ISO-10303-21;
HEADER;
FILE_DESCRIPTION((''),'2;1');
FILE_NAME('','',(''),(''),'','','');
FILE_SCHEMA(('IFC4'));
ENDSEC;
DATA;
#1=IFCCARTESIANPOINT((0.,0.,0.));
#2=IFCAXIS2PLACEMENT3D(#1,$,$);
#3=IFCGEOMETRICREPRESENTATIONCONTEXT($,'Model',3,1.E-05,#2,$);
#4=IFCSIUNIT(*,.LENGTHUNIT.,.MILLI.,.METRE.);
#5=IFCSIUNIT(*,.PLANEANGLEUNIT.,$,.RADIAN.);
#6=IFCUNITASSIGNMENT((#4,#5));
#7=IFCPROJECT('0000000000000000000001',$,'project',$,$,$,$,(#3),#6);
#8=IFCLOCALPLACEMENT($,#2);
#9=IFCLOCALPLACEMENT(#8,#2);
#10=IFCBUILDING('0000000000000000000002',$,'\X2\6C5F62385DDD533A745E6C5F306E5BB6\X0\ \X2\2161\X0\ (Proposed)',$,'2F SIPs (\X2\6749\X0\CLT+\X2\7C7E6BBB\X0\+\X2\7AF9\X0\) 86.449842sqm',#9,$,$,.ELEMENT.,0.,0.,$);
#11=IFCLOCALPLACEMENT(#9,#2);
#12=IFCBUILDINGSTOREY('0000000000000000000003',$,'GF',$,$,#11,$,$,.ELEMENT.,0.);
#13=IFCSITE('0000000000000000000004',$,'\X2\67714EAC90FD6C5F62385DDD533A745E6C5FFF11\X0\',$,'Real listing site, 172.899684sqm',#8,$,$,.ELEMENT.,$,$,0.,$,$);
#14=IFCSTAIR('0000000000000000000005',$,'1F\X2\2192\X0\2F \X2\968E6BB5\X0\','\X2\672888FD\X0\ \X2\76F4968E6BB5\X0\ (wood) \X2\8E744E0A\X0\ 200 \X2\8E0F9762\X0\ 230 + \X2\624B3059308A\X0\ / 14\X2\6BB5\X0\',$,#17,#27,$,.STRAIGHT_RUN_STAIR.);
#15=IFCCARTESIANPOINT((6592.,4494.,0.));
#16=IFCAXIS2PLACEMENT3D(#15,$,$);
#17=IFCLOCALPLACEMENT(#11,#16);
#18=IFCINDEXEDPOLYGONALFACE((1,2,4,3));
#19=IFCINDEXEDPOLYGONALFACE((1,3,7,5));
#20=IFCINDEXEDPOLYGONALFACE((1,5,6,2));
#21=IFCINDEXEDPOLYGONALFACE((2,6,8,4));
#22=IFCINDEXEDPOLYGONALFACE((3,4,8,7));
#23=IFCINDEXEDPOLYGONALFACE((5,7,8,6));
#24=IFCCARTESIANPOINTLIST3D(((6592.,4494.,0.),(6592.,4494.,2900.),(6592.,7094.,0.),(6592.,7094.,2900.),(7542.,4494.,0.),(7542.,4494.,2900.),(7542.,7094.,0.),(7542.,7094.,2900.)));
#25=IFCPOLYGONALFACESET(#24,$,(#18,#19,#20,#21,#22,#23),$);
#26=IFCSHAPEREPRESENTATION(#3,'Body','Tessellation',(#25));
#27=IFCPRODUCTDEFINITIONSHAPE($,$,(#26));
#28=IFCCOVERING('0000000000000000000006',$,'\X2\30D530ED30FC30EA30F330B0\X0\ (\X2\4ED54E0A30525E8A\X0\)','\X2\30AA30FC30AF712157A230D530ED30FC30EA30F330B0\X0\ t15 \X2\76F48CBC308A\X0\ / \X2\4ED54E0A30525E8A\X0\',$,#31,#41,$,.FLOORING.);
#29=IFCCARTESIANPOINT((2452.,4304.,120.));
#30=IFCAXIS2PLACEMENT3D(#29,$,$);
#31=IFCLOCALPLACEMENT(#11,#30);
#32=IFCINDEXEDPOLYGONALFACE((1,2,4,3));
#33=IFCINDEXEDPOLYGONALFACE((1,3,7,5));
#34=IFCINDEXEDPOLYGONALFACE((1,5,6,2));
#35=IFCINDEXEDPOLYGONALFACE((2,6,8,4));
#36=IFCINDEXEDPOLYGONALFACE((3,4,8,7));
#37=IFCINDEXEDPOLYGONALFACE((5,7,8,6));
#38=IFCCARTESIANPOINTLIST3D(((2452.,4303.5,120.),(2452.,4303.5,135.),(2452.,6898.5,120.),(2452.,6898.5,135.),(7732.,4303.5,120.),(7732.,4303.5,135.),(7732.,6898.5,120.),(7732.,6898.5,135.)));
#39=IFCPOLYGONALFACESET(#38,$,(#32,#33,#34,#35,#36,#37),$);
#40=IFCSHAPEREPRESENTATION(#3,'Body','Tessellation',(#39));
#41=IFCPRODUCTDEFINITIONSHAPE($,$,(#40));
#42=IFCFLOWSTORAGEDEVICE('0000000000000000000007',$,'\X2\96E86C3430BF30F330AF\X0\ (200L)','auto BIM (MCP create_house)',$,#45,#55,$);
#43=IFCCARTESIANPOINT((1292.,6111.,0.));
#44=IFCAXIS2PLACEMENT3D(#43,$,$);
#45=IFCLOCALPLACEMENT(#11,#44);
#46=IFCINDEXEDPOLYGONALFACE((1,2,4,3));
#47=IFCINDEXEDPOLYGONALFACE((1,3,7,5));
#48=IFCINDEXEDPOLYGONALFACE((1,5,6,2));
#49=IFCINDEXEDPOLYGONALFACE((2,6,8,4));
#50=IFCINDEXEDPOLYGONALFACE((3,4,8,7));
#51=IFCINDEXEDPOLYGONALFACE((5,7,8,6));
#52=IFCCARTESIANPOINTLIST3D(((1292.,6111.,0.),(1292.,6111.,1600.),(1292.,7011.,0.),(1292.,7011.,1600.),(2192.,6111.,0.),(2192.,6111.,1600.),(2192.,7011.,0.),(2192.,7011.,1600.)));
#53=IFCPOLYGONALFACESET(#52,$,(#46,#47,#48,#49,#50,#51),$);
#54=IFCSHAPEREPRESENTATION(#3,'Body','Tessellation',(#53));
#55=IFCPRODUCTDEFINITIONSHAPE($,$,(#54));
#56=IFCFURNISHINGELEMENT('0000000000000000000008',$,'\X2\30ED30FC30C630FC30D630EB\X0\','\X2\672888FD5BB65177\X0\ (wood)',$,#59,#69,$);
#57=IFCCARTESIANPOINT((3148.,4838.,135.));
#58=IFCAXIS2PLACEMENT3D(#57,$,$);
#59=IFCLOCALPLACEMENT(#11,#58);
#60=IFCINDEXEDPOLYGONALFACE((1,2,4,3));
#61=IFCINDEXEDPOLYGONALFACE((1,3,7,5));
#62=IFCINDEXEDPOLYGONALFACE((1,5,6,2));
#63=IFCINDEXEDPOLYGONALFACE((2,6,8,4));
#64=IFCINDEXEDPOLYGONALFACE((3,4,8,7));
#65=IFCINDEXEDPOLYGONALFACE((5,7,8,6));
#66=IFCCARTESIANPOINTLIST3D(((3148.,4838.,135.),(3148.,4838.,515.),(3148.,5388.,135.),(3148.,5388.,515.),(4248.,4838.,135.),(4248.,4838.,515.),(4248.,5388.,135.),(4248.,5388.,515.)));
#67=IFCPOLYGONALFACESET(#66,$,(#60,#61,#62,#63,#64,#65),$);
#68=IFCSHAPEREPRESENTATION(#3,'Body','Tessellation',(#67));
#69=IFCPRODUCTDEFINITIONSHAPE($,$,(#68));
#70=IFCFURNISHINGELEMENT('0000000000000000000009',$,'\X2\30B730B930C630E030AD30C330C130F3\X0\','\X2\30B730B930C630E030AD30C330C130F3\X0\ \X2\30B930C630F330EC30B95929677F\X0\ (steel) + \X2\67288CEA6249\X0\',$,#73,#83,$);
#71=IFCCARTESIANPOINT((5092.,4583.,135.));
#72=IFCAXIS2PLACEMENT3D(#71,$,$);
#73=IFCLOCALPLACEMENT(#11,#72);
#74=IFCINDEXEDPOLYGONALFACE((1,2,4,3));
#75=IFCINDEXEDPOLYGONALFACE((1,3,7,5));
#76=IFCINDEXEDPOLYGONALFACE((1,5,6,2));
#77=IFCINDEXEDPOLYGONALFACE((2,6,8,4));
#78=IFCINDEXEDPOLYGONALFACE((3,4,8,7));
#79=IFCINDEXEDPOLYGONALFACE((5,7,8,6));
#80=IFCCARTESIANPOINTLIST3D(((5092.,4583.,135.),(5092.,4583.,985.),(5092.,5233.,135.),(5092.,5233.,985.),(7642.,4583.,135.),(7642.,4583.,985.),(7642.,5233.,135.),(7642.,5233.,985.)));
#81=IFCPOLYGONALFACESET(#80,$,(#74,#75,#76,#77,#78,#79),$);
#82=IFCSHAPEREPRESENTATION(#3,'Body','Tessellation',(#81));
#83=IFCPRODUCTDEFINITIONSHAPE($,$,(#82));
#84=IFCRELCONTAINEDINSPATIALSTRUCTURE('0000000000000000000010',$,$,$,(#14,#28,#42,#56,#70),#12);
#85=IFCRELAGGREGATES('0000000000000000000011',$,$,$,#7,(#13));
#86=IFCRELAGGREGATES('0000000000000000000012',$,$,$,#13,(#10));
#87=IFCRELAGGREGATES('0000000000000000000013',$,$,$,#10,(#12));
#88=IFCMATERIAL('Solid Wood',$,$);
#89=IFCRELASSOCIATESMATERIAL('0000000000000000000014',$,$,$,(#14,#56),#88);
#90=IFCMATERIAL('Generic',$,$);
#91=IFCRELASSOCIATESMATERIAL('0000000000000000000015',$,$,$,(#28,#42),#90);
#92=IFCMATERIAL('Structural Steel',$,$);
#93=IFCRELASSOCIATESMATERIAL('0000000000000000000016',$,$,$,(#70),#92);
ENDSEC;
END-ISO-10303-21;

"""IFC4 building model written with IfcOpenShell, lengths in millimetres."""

from ifc_helpers import new_model, si_unit, frame, frame_2d, origin, place, context, project, spatial, rectangle, extrude, material, element, save


model = new_model("IFC4")

# Units and contexts
model_context = context("Model", 3, precision=1e-05, world=origin())
ifc_project = project(units=[si_unit("LENGTHUNIT", "METRE", prefix="MILLI"), si_unit("PLANEANGLEUNIT", "RADIAN")], contexts=[model_context])

# Site, building, storey
site_placement = place(None, origin())
site = spatial("IfcSite", under=ifc_project, at=site_placement, Name="東京都江戸川区瑞江１", ObjectType="Real listing site, 172.899684sqm", CompositionType="ELEMENT", RefElevation=0.0)
building_placement = place(site_placement, origin())
building = spatial("IfcBuilding", under=site, at=building_placement, Name="江戸川区瑞江の家 Ⅱ (Proposed)", ObjectType="2F SIPs (杉CLT+籾殻+竹) 86.449842sqm", CompositionType="ELEMENT", ElevationOfRefHeight=0.0, ElevationOfTerrain=0.0)
storey_placement = place(building_placement, origin())
storey = spatial("IfcBuildingStorey", under=building, at=storey_placement, Name="GF", CompositionType="ELEMENT", Elevation=0.0)

# Shared definitions
ifc_material_1 = material(Name="Solid Wood")

# Stair
stair_placement = place(storey_placement, frame((6592.0, 4494.0, 0.0)))
element("IfcStair", 1, at=stair_placement, inside=storey, material=ifc_material_1, Name="1F→2F 階段", Description="木製 直階段 (wood) 蹴上 200 踏面 230 + 手すり / 14段", PredefinedType="STRAIGHT_RUN_STAIR", context=model_context, shape_type="SweptSolid", body=[
    extrude(rectangle(XDim=950.0, YDim=2600.0, at=frame_2d((475.0, 1300.0))), frame((6592.0, 4494.0, 0.0)), (0.0, 0.0, 1.0), 2900.0),
])

# Covering
ifc_material_2 = material(Name="Generic")
covering_placement = place(storey_placement, frame((2452.0, 4304.0, 120.0)))
element("IfcCovering", 2, at=covering_placement, inside=storey, material=ifc_material_2, Name="フローリング (仕上げ床)", Description="オーク無垢フローリング t15 直貼り / 仕上げ床", PredefinedType="FLOORING", context=model_context, shape_type="SweptSolid", body=[
    extrude(rectangle(XDim=5280.0, YDim=2595.0, at=frame_2d((2640.0, 1297.0))), frame((2452.0, 4304.0, 120.0)), (0.0, 0.0, 1.0), 15.0),
])

# Flow storage device
flow_storage_device_placement = place(storey_placement, frame((1292.0, 6111.0, 0.0)))
element("IfcFlowStorageDevice", 3, at=flow_storage_device_placement, inside=storey, material=ifc_material_2, Name="雨水タンク (200L)", Description="auto BIM (MCP create_house)", context=model_context, shape_type="SweptSolid", body=[
    extrude(rectangle(XDim=900.0, YDim=900.0, at=frame_2d((450.0, 450.0))), frame((1292.0, 6111.0, 0.0)), (0.0, 0.0, 1.0), 1600.0),
])

# Furnishing elements
furnishing_1_placement = place(storey_placement, frame((3148.0, 4838.0, 135.0)))
element("IfcFurnishingElement", 4, at=furnishing_1_placement, inside=storey, material=ifc_material_1, Name="ローテーブル", Description="木製家具 (wood)", context=model_context, shape_type="SweptSolid", body=[
    extrude(rectangle(XDim=1100.0, YDim=550.0, at=frame_2d((550.0, 275.0))), frame((3148.0, 4838.0, 135.0)), (0.0, 0.0, 1.0), 380.0),
])
ifc_material_3 = material(Name="Structural Steel")
furnishing_2_placement = place(storey_placement, frame((5092.0, 4583.0, 135.0)))
element("IfcFurnishingElement", 5, at=furnishing_2_placement, inside=storey, material=ifc_material_3, Name="システムキッチン", Description="システムキッチン ステンレス天板 (steel) + 木質扉", context=model_context, shape_type="SweptSolid", body=[
    extrude(rectangle(XDim=2550.0, YDim=650.0, at=frame_2d((1275.0, 325.0))), frame((5092.0, 4583.0, 135.0)), (0.0, 0.0, 1.0), 850.0),
])

save(model, "model.ifc")
